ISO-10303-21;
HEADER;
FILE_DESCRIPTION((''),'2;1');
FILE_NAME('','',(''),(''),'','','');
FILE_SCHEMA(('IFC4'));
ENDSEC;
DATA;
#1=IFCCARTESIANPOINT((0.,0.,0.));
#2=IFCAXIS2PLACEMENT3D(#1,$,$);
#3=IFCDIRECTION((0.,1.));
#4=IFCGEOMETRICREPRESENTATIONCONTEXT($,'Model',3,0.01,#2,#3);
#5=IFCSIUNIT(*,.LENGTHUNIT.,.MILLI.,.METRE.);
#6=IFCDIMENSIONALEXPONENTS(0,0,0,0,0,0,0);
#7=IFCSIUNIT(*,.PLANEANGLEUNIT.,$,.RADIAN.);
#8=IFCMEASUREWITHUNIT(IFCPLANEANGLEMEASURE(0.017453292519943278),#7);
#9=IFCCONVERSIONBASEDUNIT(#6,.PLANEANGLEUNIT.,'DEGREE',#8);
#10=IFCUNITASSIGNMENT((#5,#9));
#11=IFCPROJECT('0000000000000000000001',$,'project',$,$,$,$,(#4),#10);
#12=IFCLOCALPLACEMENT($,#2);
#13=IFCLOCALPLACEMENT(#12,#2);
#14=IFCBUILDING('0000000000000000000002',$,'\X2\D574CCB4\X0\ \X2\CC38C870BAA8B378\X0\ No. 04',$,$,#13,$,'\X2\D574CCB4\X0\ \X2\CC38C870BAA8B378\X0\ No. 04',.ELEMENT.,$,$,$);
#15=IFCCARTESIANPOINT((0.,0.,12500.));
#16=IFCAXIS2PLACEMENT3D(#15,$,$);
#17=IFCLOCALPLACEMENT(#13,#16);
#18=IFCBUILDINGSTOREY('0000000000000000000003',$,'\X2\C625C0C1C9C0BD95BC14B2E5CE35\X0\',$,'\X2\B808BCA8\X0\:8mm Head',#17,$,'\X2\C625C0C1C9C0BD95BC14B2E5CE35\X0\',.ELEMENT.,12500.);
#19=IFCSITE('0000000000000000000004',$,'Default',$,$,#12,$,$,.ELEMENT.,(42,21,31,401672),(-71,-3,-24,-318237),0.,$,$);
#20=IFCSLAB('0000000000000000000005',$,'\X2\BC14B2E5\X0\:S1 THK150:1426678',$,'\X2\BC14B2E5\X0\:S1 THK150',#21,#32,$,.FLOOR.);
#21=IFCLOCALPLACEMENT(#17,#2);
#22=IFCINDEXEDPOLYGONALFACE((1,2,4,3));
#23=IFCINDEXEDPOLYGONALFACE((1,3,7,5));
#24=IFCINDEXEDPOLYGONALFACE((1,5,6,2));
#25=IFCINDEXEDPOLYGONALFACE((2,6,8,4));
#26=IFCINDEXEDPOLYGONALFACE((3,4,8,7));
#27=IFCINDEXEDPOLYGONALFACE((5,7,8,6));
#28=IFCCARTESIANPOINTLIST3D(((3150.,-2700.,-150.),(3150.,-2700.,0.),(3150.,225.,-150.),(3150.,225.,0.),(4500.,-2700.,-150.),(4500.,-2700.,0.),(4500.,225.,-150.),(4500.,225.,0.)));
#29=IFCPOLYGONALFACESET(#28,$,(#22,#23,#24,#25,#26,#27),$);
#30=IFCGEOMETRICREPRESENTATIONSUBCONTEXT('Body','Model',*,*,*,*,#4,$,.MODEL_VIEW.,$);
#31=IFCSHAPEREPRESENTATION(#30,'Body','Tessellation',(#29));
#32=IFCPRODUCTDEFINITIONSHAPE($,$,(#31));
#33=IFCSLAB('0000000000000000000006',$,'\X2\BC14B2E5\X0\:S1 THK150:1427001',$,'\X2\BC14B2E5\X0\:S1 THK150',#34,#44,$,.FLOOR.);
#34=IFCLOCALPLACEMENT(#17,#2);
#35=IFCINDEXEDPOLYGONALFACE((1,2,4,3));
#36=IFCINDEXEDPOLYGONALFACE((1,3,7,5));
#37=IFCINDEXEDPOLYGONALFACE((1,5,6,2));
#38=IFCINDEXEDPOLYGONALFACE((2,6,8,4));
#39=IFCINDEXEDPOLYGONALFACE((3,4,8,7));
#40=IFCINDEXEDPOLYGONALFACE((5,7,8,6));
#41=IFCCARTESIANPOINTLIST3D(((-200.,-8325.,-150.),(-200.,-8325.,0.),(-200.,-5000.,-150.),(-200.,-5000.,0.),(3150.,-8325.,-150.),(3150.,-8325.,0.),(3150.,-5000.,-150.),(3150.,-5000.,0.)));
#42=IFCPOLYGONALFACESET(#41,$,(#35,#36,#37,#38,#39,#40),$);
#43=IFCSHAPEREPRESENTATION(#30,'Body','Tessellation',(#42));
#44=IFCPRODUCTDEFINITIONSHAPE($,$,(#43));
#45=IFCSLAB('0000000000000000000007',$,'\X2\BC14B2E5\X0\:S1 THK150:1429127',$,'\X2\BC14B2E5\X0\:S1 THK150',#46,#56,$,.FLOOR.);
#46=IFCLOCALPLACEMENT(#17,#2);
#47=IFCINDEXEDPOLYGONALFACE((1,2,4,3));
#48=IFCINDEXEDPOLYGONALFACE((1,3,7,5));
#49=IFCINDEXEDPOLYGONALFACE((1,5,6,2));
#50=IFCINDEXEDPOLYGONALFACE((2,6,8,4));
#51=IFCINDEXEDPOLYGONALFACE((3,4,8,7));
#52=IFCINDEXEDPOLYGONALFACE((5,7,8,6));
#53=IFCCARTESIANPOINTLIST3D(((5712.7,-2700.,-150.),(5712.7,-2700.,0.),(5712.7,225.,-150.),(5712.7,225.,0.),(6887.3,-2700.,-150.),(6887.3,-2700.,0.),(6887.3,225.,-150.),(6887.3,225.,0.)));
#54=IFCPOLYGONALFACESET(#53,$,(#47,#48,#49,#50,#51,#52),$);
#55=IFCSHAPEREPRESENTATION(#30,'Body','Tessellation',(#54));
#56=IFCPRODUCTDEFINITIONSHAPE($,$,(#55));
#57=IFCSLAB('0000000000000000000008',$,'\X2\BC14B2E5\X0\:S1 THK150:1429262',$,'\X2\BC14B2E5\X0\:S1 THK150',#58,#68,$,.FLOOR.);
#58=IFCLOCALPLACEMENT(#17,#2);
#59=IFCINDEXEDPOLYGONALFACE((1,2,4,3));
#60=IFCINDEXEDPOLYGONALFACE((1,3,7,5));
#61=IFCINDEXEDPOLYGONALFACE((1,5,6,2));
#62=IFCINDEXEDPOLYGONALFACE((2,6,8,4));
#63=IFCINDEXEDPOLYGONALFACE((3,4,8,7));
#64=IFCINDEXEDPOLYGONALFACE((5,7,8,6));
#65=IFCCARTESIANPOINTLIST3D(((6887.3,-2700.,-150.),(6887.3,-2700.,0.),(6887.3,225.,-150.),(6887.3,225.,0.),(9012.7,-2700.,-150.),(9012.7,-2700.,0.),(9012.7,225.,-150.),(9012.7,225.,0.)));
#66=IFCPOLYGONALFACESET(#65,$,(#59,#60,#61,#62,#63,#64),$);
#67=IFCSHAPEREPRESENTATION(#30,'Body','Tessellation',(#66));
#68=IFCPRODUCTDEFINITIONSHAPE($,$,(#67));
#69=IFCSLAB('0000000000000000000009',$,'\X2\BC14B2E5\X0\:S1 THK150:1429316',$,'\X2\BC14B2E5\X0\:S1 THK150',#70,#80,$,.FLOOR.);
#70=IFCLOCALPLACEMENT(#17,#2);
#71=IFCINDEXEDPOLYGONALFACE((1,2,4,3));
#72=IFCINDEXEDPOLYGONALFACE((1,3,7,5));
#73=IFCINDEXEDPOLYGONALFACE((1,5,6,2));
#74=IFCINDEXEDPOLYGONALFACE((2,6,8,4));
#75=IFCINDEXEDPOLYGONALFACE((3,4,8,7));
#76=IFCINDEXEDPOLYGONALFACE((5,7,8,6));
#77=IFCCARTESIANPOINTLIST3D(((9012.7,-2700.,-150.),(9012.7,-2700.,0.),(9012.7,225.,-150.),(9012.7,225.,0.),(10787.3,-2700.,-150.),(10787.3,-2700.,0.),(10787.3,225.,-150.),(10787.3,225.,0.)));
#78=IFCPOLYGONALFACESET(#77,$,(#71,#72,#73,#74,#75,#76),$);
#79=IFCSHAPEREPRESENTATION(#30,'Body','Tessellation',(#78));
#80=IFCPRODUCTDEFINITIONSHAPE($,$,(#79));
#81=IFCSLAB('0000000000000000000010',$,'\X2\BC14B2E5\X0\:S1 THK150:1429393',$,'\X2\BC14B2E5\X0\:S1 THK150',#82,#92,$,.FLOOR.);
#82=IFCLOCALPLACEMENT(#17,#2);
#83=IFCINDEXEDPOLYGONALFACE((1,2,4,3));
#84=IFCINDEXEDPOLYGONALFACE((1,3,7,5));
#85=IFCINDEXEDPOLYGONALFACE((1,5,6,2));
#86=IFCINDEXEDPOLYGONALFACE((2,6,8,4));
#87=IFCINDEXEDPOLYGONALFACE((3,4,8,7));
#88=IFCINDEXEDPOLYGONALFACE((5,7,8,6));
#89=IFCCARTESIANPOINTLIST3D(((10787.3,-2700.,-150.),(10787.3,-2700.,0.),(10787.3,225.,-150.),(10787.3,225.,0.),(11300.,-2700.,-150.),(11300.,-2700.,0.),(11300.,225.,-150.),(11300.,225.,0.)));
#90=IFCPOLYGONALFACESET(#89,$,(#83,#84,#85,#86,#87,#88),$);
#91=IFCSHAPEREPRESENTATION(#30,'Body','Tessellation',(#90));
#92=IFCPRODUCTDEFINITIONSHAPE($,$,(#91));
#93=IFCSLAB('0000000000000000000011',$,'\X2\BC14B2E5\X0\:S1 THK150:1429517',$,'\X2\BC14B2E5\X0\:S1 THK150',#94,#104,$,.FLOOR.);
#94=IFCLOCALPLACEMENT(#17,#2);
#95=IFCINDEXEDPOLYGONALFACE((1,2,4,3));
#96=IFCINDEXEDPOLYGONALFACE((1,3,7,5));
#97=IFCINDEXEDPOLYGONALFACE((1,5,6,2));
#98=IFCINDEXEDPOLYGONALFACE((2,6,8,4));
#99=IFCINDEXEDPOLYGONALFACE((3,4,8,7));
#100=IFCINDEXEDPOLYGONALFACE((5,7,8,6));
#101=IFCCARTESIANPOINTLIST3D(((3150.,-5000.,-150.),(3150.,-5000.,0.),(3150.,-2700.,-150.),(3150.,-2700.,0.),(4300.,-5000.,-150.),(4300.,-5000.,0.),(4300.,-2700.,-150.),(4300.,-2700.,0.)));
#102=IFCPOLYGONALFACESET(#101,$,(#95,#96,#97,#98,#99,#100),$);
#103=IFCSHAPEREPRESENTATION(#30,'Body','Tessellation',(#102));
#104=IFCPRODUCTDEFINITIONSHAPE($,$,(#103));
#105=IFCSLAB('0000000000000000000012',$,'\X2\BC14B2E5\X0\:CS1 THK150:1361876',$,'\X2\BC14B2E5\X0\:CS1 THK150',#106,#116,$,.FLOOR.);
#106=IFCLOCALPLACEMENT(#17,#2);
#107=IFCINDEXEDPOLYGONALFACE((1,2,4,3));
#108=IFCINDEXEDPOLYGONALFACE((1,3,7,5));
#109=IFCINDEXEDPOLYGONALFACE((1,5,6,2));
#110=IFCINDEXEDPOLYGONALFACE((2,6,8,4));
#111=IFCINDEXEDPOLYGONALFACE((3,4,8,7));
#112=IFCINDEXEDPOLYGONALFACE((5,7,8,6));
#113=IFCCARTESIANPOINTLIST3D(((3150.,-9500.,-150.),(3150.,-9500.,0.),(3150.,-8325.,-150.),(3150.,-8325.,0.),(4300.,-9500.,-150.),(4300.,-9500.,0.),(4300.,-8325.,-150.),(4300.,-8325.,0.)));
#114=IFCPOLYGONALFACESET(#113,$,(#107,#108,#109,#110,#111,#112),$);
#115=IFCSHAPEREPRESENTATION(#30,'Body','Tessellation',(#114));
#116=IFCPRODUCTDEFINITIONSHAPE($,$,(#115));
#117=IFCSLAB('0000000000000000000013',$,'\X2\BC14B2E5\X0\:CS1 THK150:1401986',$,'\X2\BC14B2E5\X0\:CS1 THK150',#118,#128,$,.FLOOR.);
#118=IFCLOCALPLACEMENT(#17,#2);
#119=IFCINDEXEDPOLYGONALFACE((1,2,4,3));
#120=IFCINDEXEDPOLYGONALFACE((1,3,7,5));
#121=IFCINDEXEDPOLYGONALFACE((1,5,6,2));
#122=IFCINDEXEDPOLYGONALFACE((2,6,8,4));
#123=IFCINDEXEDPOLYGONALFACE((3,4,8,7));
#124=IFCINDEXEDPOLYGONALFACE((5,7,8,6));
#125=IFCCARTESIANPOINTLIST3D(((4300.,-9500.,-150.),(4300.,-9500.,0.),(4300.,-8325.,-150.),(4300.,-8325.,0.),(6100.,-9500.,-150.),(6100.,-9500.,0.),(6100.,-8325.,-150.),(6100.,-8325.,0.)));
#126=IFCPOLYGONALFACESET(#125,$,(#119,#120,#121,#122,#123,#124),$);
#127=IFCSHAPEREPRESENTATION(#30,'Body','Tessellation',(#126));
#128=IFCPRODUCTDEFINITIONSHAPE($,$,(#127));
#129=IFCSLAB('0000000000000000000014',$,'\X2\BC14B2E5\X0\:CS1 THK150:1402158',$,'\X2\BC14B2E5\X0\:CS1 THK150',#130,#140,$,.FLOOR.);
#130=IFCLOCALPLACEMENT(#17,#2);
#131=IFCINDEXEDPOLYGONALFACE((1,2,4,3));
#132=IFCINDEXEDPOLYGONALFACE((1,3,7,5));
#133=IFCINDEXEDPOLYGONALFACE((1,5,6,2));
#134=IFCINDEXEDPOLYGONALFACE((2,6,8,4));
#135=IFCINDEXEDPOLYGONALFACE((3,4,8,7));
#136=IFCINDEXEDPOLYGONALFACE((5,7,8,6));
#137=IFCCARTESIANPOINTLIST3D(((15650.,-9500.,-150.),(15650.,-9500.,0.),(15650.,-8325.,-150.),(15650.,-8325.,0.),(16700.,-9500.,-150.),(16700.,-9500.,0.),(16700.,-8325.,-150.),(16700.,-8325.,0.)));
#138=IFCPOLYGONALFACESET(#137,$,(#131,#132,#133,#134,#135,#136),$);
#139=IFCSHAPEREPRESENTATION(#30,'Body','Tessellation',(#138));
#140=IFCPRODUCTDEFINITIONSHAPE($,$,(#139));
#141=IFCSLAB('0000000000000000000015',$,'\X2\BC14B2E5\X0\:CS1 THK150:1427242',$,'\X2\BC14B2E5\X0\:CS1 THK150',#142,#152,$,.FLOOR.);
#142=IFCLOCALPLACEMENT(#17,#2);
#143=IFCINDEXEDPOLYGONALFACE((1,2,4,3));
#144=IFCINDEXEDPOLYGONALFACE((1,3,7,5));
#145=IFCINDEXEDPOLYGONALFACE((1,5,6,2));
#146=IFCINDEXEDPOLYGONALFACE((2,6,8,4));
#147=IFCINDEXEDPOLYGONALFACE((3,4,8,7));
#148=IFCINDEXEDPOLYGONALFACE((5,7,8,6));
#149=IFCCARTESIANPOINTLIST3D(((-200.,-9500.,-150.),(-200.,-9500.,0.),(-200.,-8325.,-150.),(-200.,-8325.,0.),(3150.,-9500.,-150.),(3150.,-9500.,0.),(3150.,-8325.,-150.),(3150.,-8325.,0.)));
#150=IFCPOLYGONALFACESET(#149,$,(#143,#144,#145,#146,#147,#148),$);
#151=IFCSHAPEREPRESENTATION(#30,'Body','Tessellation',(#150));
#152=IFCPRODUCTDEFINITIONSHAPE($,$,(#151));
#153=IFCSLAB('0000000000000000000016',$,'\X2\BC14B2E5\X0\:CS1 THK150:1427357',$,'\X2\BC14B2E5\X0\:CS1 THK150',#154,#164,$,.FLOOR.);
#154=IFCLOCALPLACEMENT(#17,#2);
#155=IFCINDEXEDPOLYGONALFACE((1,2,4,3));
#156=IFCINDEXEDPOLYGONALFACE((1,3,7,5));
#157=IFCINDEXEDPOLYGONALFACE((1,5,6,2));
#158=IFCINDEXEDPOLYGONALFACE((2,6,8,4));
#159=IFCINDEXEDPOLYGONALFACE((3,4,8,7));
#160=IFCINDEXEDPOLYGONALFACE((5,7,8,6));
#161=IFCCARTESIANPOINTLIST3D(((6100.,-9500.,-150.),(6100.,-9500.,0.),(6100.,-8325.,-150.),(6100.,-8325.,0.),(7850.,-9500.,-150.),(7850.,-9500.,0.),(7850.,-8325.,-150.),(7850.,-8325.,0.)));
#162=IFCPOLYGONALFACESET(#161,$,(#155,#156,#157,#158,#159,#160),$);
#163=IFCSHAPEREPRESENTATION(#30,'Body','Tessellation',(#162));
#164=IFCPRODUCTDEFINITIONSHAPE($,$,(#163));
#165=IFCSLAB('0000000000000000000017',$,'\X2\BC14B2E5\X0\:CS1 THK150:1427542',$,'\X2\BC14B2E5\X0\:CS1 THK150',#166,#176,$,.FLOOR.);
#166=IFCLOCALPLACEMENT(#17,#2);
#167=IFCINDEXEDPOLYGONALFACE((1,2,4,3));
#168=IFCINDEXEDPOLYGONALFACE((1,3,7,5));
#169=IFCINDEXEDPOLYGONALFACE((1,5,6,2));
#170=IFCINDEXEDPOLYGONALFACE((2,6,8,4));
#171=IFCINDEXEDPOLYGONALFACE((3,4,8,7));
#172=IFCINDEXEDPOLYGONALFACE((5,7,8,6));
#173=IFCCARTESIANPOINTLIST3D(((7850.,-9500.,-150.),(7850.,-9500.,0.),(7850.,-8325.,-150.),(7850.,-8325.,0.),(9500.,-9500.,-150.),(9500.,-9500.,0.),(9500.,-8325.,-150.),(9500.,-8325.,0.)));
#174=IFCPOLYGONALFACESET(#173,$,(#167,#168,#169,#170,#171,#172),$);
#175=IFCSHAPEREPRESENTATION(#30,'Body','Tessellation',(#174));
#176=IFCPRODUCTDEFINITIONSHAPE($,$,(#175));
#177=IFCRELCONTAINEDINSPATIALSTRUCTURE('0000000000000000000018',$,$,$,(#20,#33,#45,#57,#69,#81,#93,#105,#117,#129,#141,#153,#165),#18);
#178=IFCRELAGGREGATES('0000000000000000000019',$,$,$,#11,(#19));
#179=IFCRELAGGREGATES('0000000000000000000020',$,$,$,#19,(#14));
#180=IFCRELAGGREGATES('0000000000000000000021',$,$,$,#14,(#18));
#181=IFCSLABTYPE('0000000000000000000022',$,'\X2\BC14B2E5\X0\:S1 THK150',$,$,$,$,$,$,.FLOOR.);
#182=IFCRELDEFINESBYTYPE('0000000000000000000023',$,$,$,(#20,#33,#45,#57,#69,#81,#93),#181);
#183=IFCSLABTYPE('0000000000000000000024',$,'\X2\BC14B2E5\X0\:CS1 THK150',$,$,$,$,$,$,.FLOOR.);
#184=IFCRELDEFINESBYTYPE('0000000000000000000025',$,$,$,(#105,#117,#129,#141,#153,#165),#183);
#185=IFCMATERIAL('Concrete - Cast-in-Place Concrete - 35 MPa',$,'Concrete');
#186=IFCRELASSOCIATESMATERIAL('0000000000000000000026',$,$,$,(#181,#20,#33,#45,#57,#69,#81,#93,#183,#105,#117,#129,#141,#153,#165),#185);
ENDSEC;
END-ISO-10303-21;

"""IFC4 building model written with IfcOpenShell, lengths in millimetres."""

from ifc_helpers import new_model, entity, si_unit, converted_unit, direction, frame, origin, place, context, subcontext, project, spatial, indexed_curve, outline, extrude, material, type_object, element, save


model = new_model("IFC4")

# Units and contexts
model_context = context("Model", 3, precision=0.01, world=origin(), true_north=direction((0.0, 1.0)))
body_context = subcontext(model_context, "Body", "Model", "MODEL_VIEW")
ifc_project = project(units=[si_unit("LENGTHUNIT", "METRE", prefix="MILLI"), converted_unit("PLANEANGLEUNIT", "DEGREE", entity("IfcPlaneAngleMeasure", 0.017453292519943278), si_unit("PLANEANGLEUNIT", "RADIAN"), dimensions=[0, 0, 0, 0, 0, 0, 0])], contexts=[model_context])

# Site, building, storey
site_placement = place(None, origin())
site = spatial("IfcSite", under=ifc_project, at=site_placement, Name="Default", CompositionType="ELEMENT", RefLatitude=(42, 21, 31, 401672), RefLongitude=(-71, -3, -24, -318237), RefElevation=0.0)
building_placement = place(site_placement, origin())
building = spatial("IfcBuilding", under=site, at=building_placement, Name="해체 참조모델 No. 04", LongName="해체 참조모델 No. 04", CompositionType="ELEMENT")
storey_placement = place(building_placement, frame((0.0, 0.0, 12500.0)))
storey = spatial("IfcBuildingStorey", under=building, at=storey_placement, Name="옥상지붕바닥층", ObjectType="레벨:8mm Head", LongName="옥상지붕바닥층", CompositionType="ELEMENT", Elevation=12500.0)

# Shared definitions
ifc_material_1 = material(Name="Concrete - Cast-in-Place Concrete - 35 MPa", Category="Concrete")

# Slabs
slab_type_1 = type_object("IfcSlabType", Name="바닥:S1 THK150", PredefinedType="FLOOR", material=ifc_material_1)
slab_1_placement = place(storey_placement, origin())
element("IfcSlab", 1, at=slab_1_placement, inside=storey, type_object=slab_type_1, material=ifc_material_1, Name="바닥:S1 THK150:1426678", ObjectType="바닥:S1 THK150", PredefinedType="FLOOR", context=body_context, shape_type="SweptSolid", body=[
    extrude(outline(indexed_curve([(-1462.5, -675.0), (1462.5, -675.0), (1462.5, 675.0), (-1462.5, 675.0), (-1462.5, -675.0)], self_intersect=False)), frame((3825.0, -1237.5, 0.0), z_axis=(0.0, 0.0, -1.0), x_axis=(0.0, 1.0, 0.0)), (0.0, 0.0, 1.0), 150.0),
])
slab_2_placement = place(storey_placement, origin())
element("IfcSlab", 2, at=slab_2_placement, inside=storey, type_object=slab_type_1, material=ifc_material_1, Name="바닥:S1 THK150:1427001", ObjectType="바닥:S1 THK150", PredefinedType="FLOOR", context=body_context, shape_type="SweptSolid", body=[
    extrude(outline(indexed_curve([(-1662.5, -1675.0), (1662.5, -1675.0), (1662.5, 1675.0), (-1662.5, 1675.0), (-1662.5, -1675.0)], self_intersect=False)), frame((1475.0, -6662.5, 0.0), z_axis=(0.0, 0.0, -1.0), x_axis=(0.0, 1.0, 0.0)), (0.0, 0.0, 1.0), 150.0),
])
slab_3_placement = place(storey_placement, origin())
element("IfcSlab", 3, at=slab_3_placement, inside=storey, type_object=slab_type_1, material=ifc_material_1, Name="바닥:S1 THK150:1429127", ObjectType="바닥:S1 THK150", PredefinedType="FLOOR", context=body_context, shape_type="SweptSolid", body=[
    extrude(outline(indexed_curve([(-1462.5, -587.3), (1462.5, -587.3), (1462.5, 587.3), (-1462.5, 587.3), (-1462.5, -587.3)], self_intersect=False)), frame((6300.0, -1237.5, 0.0), z_axis=(0.0, 0.0, -1.0), x_axis=(0.0, 1.0, 0.0)), (0.0, 0.0, 1.0), 150.0),
])
slab_4_placement = place(storey_placement, origin())
element("IfcSlab", 4, at=slab_4_placement, inside=storey, type_object=slab_type_1, material=ifc_material_1, Name="바닥:S1 THK150:1429262", ObjectType="바닥:S1 THK150", PredefinedType="FLOOR", context=body_context, shape_type="SweptSolid", body=[
    extrude(outline(indexed_curve([(-1462.5, -1062.7), (1462.5, -1062.7), (1462.5, 1062.7), (-1462.5, 1062.7), (-1462.5, -1062.7)], self_intersect=False)), frame((7950.0, -1237.5, 0.0), z_axis=(0.0, 0.0, -1.0), x_axis=(0.0, 1.0, 0.0)), (0.0, 0.0, 1.0), 150.0),
])
slab_5_placement = place(storey_placement, origin())
element("IfcSlab", 5, at=slab_5_placement, inside=storey, type_object=slab_type_1, material=ifc_material_1, Name="바닥:S1 THK150:1429316", ObjectType="바닥:S1 THK150", PredefinedType="FLOOR", context=body_context, shape_type="SweptSolid", body=[
    extrude(outline(indexed_curve([(-1462.5, -887.3), (1462.5, -887.3), (1462.5, 887.3), (-1462.5, 887.3), (-1462.5, -887.3)], self_intersect=False)), frame((9900.0, -1237.5, 0.0), z_axis=(0.0, 0.0, -1.0), x_axis=(0.0, 1.0, 0.0)), (0.0, 0.0, 1.0), 150.0),
])
slab_6_placement = place(storey_placement, origin())
element("IfcSlab", 6, at=slab_6_placement, inside=storey, type_object=slab_type_1, material=ifc_material_1, Name="바닥:S1 THK150:1429393", ObjectType="바닥:S1 THK150", PredefinedType="FLOOR", context=body_context, shape_type="SweptSolid", body=[
    extrude(outline(indexed_curve([(-1462.5, -256.3), (1462.5, -256.3), (1462.5, 256.3), (-1462.5, 256.3), (-1462.5, -256.3)], self_intersect=False)), frame((11043.7, -1237.5, 0.0), z_axis=(0.0, 0.0, -1.0), x_axis=(0.0, 1.0, 0.0)), (0.0, 0.0, 1.0), 150.0),
])
slab_7_placement = place(storey_placement, origin())
element("IfcSlab", 7, at=slab_7_placement, inside=storey, type_object=slab_type_1, material=ifc_material_1, Name="바닥:S1 THK150:1429517", ObjectType="바닥:S1 THK150", PredefinedType="FLOOR", context=body_context, shape_type="SweptSolid", body=[
    extrude(outline(indexed_curve([(-1150.0, -575.0), (1150.0, -575.0), (1150.0, 575.0), (-1150.0, 575.0), (-1150.0, -575.0)], self_intersect=False)), frame((3725.0, -3850.0, 0.0), z_axis=(0.0, 0.0, -1.0), x_axis=(0.0, 1.0, 0.0)), (0.0, 0.0, 1.0), 150.0),
])
slab_type_2 = type_object("IfcSlabType", Name="바닥:CS1 THK150", PredefinedType="FLOOR", material=ifc_material_1)
slab_8_placement = place(storey_placement, origin())
element("IfcSlab", 8, at=slab_8_placement, inside=storey, type_object=slab_type_2, material=ifc_material_1, Name="바닥:CS1 THK150:1361876", ObjectType="바닥:CS1 THK150", PredefinedType="FLOOR", context=body_context, shape_type="SweptSolid", body=[
    extrude(outline(indexed_curve([(-587.5, -575.0), (587.5, -575.0), (587.5, 575.0), (-587.5, 575.0), (-587.5, -575.0)], self_intersect=False)), frame((3725.0, -8912.5, 0.0), z_axis=(0.0, 0.0, -1.0), x_axis=(0.0, 1.0, 0.0)), (0.0, 0.0, 1.0), 150.0),
])
slab_9_placement = place(storey_placement, origin())
element("IfcSlab", 9, at=slab_9_placement, inside=storey, type_object=slab_type_2, material=ifc_material_1, Name="바닥:CS1 THK150:1401986", ObjectType="바닥:CS1 THK150", PredefinedType="FLOOR", context=body_context, shape_type="SweptSolid", body=[
    extrude(outline(indexed_curve([(-587.5, -900.0), (587.5, -900.0), (587.5, 900.0), (-587.5, 900.0), (-587.5, -900.0)], self_intersect=False)), frame((5200.0, -8912.5, 0.0), z_axis=(0.0, 0.0, -1.0), x_axis=(0.0, 1.0, 0.0)), (0.0, 0.0, 1.0), 150.0),
])
slab_10_placement = place(storey_placement, origin())
element("IfcSlab", 10, at=slab_10_placement, inside=storey, type_object=slab_type_2, material=ifc_material_1, Name="바닥:CS1 THK150:1402158", ObjectType="바닥:CS1 THK150", PredefinedType="FLOOR", context=body_context, shape_type="SweptSolid", body=[
    extrude(outline(indexed_curve([(-587.5, -525.0), (587.5, -525.0), (587.5, 525.0), (-587.5, 525.0), (-587.5, -525.0)], self_intersect=False)), frame((16175.0, -8912.5, 0.0), z_axis=(0.0, 0.0, -1.0), x_axis=(0.0, 1.0, 0.0)), (0.0, 0.0, 1.0), 150.0),
])
slab_11_placement = place(storey_placement, origin())
element("IfcSlab", 11, at=slab_11_placement, inside=storey, type_object=slab_type_2, material=ifc_material_1, Name="바닥:CS1 THK150:1427242", ObjectType="바닥:CS1 THK150", PredefinedType="FLOOR", context=body_context, shape_type="SweptSolid", body=[
    extrude(outline(indexed_curve([(-587.5, -1675.0), (587.5, -1675.0), (587.5, 1675.0), (-587.5, 1675.0), (-587.5, -1675.0)], self_intersect=False)), frame((1475.0, -8912.5, 0.0), z_axis=(0.0, 0.0, -1.0), x_axis=(0.0, 1.0, 0.0)), (0.0, 0.0, 1.0), 150.0),
])
slab_12_placement = place(storey_placement, origin())
element("IfcSlab", 12, at=slab_12_placement, inside=storey, type_object=slab_type_2, material=ifc_material_1, Name="바닥:CS1 THK150:1427357", ObjectType="바닥:CS1 THK150", PredefinedType="FLOOR", context=body_context, shape_type="SweptSolid", body=[
    extrude(outline(indexed_curve([(-587.5, -875.0), (587.5, -875.0), (587.5, 875.0), (-587.5, 875.0), (-587.5, -875.0)], self_intersect=False)), frame((6975.0, -8912.5, 0.0), z_axis=(0.0, 0.0, -1.0), x_axis=(0.0, 1.0, 0.0)), (0.0, 0.0, 1.0), 150.0),
])
slab_13_placement = place(storey_placement, origin())
element("IfcSlab", 13, at=slab_13_placement, inside=storey, type_object=slab_type_2, material=ifc_material_1, Name="바닥:CS1 THK150:1427542", ObjectType="바닥:CS1 THK150", PredefinedType="FLOOR", context=body_context, shape_type="SweptSolid", body=[
    extrude(outline(indexed_curve([(-587.5, -825.0), (587.5, -825.0), (587.5, 825.0), (-587.5, 825.0), (-587.5, -825.0)], self_intersect=False)), frame((8675.0, -8912.5, 0.0), z_axis=(0.0, 0.0, -1.0), x_axis=(0.0, 1.0, 0.0)), (0.0, 0.0, 1.0), 150.0),
])

save(model, "model.ifc")
